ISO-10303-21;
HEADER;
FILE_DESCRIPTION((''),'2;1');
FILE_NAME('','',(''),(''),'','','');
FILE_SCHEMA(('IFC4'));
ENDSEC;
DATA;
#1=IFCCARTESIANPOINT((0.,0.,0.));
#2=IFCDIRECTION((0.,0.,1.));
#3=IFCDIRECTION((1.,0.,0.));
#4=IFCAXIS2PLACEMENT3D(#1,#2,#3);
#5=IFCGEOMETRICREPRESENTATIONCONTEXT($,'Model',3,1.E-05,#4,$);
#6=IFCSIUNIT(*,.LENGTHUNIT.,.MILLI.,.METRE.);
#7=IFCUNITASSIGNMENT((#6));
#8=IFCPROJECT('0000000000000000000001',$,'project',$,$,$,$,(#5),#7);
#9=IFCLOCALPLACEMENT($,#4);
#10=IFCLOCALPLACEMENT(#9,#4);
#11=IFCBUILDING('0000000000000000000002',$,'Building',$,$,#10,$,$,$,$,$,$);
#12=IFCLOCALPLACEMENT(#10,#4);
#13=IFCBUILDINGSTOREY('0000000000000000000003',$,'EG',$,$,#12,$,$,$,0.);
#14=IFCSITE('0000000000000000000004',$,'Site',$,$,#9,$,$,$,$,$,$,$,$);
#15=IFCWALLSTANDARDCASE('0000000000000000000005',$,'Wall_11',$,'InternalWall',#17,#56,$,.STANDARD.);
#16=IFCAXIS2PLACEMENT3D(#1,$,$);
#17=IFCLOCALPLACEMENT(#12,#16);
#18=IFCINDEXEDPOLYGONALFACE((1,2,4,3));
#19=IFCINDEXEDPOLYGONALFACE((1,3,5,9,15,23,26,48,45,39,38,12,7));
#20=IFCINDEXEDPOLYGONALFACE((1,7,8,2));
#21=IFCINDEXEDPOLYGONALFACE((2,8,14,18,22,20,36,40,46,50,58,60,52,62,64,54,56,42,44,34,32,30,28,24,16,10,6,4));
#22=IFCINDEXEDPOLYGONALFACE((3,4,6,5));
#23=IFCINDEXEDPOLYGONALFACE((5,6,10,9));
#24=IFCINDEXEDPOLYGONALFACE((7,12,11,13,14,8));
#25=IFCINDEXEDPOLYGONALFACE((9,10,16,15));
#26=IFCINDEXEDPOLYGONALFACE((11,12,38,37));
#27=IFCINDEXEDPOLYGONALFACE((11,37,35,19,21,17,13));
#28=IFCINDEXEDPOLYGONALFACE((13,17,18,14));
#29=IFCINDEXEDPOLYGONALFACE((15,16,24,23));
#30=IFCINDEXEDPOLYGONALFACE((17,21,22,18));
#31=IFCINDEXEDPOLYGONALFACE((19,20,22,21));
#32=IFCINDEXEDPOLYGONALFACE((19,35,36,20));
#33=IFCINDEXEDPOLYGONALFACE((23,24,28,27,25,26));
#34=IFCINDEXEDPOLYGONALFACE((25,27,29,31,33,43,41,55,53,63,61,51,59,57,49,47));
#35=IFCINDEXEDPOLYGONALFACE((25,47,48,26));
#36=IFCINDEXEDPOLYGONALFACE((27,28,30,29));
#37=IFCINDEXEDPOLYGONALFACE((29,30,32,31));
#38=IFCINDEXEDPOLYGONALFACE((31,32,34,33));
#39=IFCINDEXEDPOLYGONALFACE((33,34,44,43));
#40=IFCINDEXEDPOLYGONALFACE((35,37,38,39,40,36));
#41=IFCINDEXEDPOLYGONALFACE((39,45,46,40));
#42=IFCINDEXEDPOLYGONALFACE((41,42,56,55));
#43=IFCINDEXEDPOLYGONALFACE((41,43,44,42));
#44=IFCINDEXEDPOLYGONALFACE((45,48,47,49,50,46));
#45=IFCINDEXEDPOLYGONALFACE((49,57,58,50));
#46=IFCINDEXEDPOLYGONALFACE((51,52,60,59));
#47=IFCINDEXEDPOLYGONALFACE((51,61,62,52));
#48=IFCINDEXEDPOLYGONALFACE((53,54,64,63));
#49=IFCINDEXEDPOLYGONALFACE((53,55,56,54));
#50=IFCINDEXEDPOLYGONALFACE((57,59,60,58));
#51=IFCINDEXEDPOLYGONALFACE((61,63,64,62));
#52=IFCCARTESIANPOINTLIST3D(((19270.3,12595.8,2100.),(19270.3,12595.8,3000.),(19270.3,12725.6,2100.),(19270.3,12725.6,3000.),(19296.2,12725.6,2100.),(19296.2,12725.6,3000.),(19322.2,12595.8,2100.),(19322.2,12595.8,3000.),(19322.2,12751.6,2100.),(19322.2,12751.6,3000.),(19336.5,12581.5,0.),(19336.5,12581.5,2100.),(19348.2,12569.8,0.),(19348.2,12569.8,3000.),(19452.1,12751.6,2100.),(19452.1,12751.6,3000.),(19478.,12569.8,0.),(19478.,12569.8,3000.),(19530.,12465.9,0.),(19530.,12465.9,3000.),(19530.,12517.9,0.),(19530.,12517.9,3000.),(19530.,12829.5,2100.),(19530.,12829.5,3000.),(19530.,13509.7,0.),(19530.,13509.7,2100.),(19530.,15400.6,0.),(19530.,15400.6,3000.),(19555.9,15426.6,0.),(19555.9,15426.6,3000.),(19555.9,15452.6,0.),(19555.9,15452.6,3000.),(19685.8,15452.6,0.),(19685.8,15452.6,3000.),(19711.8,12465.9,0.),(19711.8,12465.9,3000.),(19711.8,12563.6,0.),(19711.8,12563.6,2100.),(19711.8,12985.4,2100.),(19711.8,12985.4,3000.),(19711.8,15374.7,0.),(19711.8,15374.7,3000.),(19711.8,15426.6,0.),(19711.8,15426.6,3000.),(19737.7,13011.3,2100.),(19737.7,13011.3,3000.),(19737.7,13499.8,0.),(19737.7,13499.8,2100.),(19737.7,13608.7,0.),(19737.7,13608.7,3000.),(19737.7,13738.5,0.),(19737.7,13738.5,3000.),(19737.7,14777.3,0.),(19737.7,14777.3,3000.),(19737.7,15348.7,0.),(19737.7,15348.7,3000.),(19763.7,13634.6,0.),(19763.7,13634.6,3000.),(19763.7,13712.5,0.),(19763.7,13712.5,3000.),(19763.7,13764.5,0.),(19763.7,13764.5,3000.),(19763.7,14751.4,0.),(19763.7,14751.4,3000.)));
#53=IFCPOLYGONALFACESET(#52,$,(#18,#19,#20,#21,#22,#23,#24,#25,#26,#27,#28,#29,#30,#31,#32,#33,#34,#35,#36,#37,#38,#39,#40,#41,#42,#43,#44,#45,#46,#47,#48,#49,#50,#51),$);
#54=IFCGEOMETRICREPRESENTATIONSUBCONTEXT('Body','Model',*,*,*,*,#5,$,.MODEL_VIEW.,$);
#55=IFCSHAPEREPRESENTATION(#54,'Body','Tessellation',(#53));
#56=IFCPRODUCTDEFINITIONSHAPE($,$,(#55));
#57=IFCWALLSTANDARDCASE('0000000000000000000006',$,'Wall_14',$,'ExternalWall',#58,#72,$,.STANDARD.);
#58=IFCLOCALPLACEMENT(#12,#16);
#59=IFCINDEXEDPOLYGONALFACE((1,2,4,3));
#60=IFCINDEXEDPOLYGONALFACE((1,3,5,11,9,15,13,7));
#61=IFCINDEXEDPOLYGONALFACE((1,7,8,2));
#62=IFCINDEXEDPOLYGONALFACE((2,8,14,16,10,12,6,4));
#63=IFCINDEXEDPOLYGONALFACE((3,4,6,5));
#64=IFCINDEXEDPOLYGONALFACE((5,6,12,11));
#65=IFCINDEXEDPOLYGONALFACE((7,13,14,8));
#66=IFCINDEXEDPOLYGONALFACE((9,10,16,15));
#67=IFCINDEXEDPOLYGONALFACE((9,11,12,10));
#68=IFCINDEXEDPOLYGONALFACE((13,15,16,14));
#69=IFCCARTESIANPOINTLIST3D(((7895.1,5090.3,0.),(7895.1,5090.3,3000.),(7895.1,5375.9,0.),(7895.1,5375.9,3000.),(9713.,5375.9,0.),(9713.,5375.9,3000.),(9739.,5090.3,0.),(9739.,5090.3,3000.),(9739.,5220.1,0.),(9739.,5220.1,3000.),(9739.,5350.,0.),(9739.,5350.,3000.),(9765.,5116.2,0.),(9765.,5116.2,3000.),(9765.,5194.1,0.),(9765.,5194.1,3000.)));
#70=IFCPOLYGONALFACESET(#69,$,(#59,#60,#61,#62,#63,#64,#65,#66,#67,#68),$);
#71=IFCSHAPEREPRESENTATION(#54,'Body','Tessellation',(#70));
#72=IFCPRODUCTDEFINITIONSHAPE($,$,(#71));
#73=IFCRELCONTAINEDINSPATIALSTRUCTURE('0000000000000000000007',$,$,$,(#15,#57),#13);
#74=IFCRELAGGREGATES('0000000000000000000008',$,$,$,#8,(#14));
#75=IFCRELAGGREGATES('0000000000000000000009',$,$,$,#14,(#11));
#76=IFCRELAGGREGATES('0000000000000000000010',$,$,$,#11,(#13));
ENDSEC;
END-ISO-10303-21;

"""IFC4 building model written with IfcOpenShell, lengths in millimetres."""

from ifc_helpers import new_model, si_unit, frame, origin_with_axes, place, context, subcontext, project, spatial, polyline, rectangle, outline, extrude, element, save


model = new_model("IFC4")

# Units and contexts
model_context = context("Model", 3, precision=1e-05, world=origin_with_axes())
body_context = subcontext(model_context, "Body", "Model", "MODEL_VIEW")
ifc_project = project(units=[si_unit("LENGTHUNIT", "METRE", prefix="MILLI")], contexts=[model_context])

# Site, building, storey
site_placement = place(None, origin_with_axes())
site = spatial("IfcSite", under=ifc_project, at=site_placement, Name="Site")
building_placement = place(site_placement, origin_with_axes())
building = spatial("IfcBuilding", under=site, at=building_placement, Name="Building")
storey_placement = place(building_placement, origin_with_axes())
storey = spatial("IfcBuildingStorey", under=building, at=storey_placement, Name="EG", Elevation=0.0)

# Walls, openings
wall_1_placement = place(storey_placement, origin_with_axes())
wall_1 = element("IfcWallStandardCase", 1, at=wall_1_placement, inside=storey, Name="Wall_11", ObjectType="InternalWall", PredefinedType="STANDARD", context=body_context, shape_type="SweptSolid", body=[
    extrude(outline(polyline([(19530.0, 12465.9, 0.0), (19530.0, 12517.9, 0.0), (19478.0, 12569.8, 0.0), (19348.2, 12569.8, 0.0), (19322.2, 12595.8, 0.0), (19270.3, 12595.8, 0.0), (19270.3, 12725.6, 0.0), (19296.2, 12725.6, 0.0), (19322.2, 12751.6, 0.0), (19452.1, 12751.6, 0.0), (19530.0, 12829.5, 0.0), (19530.0, 15400.6, 0.0), (19555.9, 15426.6, 0.0), (19555.9, 15452.6, 0.0), (19685.8, 15452.6, 0.0), (19711.8, 15426.6, 0.0), (19711.8, 15374.7, 0.0), (19737.7, 15348.7, 0.0), (19737.7, 14777.3, 0.0), (19763.7, 14751.4, 0.0), (19763.7, 13764.5, 0.0), (19737.7, 13738.5, 0.0), (19763.7, 13712.5, 0.0), (19763.7, 13634.6, 0.0), (19737.7, 13608.7, 0.0), (19737.7, 13011.3, 0.0), (19711.8, 12985.4, 0.0), (19711.8, 12465.9, 0.0), (19530.0, 12465.9, 0.0)])), origin_with_axes(), (0.0, 0.0, 1.0), 3000.0),
])
opening_1_placement = place(wall_1_placement, origin_with_axes())
element("IfcOpeningElement", 2, at=opening_1_placement, inside=storey, cuts=wall_1, context=body_context, shape_type="SweptSolid", body=[
    extrude(rectangle(XDim=936.4, YDim=453.4), frame((19512.3, 13041.9, 0.0), z_axis=(0.0, 0.0, 1.0), x_axis=(-0.047565, -0.998868, 0.0)), (0.0, 0.0, 1.0), 2100.0),
])
wall_2_placement = place(storey_placement, origin_with_axes())
wall_2 = element("IfcWallStandardCase", 3, at=wall_2_placement, inside=storey, Name="Wall_14", ObjectType="ExternalWall", PredefinedType="STANDARD", context=body_context, shape_type="SweptSolid", body=[
    extrude(outline(polyline([(7895.1, 5090.3, 0.0), (7895.1, 5375.9, 0.0), (9713.0, 5375.9, 0.0), (9739.0, 5350.0, 0.0), (9739.0, 5220.1, 0.0), (9765.0, 5194.1, 0.0), (9765.0, 5116.2, 0.0), (9739.0, 5090.3, 0.0), (7895.1, 5090.3, 0.0)])), origin_with_axes(), (0.0, 0.0, 1.0), 3000.0),
])
opening_2_placement = place(wall_2_placement, origin_with_axes())
element("IfcOpeningElement", 4, at=opening_2_placement, inside=storey, cuts=wall_2, context=body_context, shape_type="SweptSolid", body=[
    extrude(rectangle(XDim=1200.0, YDim=285.7), frame((10439.6, 5233.0, 1000.0), z_axis=(0.0, 0.0, 1.0), x_axis=(1.0, 0.0, 0.0)), (0.0, 0.0, 1.0), 1000.0),
])

save(model, "model.ifc")
